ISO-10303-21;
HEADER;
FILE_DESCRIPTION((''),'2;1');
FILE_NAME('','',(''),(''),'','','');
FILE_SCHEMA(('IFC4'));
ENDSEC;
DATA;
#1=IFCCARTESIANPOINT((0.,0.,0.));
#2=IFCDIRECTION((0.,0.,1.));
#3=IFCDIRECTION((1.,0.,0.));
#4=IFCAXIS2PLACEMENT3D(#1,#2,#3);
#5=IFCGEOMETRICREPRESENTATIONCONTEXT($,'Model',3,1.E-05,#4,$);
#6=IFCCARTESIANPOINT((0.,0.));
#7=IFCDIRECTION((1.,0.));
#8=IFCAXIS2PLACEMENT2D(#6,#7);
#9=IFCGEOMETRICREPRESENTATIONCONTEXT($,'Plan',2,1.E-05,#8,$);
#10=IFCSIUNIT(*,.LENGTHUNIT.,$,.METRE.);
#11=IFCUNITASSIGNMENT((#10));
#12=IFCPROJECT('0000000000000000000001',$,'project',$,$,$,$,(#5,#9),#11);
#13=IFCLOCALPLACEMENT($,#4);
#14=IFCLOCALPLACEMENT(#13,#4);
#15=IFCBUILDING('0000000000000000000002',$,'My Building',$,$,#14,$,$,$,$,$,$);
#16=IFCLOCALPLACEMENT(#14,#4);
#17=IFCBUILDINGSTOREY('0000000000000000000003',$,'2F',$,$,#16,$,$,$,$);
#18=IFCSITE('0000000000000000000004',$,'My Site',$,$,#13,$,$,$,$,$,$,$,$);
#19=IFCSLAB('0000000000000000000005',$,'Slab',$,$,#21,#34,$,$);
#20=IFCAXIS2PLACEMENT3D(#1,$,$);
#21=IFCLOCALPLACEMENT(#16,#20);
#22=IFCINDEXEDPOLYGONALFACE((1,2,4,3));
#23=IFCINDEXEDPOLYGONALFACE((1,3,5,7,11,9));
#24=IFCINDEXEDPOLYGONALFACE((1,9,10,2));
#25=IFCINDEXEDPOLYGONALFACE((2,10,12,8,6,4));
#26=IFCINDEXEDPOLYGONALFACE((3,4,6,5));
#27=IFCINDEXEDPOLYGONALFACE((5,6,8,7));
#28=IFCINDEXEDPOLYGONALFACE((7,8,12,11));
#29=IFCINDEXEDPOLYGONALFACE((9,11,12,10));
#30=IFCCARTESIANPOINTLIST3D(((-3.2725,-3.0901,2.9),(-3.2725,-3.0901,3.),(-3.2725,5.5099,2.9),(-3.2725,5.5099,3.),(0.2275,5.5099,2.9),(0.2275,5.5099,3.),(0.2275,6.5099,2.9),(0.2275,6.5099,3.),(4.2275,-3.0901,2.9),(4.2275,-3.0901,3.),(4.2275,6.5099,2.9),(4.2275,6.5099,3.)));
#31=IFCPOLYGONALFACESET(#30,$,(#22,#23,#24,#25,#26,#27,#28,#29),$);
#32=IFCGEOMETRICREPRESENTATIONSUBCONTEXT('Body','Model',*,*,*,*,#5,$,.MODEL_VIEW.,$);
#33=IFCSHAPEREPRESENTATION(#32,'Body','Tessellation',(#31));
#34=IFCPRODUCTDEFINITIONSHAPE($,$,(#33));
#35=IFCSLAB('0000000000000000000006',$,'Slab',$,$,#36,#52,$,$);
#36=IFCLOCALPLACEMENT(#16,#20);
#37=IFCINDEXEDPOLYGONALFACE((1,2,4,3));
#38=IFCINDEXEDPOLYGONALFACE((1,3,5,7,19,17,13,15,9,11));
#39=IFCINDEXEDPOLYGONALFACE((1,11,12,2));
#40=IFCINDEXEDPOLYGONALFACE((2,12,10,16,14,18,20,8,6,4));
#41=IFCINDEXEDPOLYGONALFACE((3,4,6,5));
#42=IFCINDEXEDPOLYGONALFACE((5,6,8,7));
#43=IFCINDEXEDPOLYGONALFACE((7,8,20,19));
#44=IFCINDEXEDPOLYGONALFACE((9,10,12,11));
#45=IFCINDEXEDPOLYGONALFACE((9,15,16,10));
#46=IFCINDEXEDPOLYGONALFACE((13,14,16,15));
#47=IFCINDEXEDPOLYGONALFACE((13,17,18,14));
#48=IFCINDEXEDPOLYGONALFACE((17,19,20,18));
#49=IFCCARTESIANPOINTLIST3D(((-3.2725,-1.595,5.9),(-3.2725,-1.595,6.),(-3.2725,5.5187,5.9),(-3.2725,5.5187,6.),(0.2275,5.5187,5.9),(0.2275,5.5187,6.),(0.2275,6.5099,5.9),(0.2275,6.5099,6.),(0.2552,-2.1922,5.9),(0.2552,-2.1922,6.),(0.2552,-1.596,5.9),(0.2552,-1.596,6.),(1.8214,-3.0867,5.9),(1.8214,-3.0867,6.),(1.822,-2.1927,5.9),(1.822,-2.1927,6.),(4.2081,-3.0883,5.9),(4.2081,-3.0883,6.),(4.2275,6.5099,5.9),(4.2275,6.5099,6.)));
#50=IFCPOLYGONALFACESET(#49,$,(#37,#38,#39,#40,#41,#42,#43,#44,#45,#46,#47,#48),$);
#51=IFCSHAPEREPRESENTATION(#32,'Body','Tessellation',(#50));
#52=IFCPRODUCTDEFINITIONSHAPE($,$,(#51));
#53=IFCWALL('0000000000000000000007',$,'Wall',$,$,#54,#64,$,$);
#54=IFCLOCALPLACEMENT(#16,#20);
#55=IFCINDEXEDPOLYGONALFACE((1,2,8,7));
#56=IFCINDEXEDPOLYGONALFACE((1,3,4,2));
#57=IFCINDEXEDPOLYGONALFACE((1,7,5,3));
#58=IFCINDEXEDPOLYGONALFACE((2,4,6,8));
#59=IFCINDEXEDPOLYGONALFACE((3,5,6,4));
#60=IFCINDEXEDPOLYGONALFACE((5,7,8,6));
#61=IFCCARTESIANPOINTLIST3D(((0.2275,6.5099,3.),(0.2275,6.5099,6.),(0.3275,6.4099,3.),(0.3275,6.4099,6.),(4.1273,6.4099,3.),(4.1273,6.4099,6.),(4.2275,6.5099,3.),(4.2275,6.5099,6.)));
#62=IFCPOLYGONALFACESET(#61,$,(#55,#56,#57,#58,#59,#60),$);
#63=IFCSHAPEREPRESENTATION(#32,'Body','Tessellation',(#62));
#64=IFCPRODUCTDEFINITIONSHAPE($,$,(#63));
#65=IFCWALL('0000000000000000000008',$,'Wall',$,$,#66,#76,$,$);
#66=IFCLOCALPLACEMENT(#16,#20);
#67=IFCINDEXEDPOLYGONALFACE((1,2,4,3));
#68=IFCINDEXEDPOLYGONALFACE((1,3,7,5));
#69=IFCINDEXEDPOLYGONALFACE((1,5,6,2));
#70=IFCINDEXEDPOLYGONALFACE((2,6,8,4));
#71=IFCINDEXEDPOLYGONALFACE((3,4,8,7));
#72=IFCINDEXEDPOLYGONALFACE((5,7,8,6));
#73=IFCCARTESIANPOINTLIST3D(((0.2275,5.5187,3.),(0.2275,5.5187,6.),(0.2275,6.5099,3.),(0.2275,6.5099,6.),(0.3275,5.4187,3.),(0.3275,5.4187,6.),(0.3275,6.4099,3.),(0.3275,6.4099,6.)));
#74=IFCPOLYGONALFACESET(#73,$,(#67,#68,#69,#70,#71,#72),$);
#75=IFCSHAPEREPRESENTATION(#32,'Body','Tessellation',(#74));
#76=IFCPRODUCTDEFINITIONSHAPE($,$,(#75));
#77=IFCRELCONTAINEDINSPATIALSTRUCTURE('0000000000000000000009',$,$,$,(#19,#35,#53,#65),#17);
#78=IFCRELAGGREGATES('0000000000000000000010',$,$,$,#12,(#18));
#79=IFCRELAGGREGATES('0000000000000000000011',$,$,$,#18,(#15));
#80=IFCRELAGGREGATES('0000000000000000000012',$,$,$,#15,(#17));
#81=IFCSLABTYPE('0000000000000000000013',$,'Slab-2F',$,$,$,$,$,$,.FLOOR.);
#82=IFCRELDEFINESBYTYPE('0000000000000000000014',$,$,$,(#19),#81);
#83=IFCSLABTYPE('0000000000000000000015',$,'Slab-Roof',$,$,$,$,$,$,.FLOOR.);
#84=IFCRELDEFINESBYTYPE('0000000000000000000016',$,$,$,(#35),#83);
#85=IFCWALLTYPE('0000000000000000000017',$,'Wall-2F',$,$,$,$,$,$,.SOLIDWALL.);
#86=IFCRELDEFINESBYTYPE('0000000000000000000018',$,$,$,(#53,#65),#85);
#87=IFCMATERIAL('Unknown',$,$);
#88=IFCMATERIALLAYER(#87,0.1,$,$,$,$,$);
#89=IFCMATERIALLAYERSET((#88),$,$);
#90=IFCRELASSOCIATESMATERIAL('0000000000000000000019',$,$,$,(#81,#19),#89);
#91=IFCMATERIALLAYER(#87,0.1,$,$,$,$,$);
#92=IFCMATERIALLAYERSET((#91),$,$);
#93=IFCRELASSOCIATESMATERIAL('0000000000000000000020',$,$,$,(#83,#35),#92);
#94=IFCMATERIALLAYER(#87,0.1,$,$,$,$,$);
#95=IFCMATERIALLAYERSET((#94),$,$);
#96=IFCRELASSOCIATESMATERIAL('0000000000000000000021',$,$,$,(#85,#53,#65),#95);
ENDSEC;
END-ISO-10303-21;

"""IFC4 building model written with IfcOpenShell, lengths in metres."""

from ifc_helpers import new_model, si_unit, frame, origin_with_axes, origin_2d_with_axis, place, context, subcontext, project, spatial, line, indexed_curve, outline, extrude, material, layer, layer_set, layer_usage, type_object, element, save


model = new_model("IFC4")

# Units and contexts
model_context = context("Model", 3, precision=1e-05, world=origin_with_axes())
plan_context = context("Plan", 2, precision=1e-05, world=origin_2d_with_axis())
body_context_1 = subcontext(model_context, "Body", "Model", "MODEL_VIEW")
ifc_project = project(units=[si_unit("LENGTHUNIT", "METRE")], contexts=[model_context, plan_context])

# Site, building, storey
site_placement = place(None, origin_with_axes())
site = spatial("IfcSite", under=ifc_project, at=site_placement, Name="My Site")
building_placement = place(site_placement, origin_with_axes())
building = spatial("IfcBuilding", under=site, at=building_placement, Name="My Building")
storey_placement = place(building_placement, origin_with_axes())
storey = spatial("IfcBuildingStorey", under=building, at=storey_placement, Name="2F")

# Slabs
ifc_material_1 = material(Name="Unknown")
ifc_layer_1 = layer(ifc_material_1, 0.1)
ifc_layer_set_1 = layer_set([ifc_layer_1])
ifc_layer_usage_1 = layer_usage(ifc_layer_set_1, "AXIS3", "POSITIVE", -0.1)
slab_type_1 = type_object("IfcSlabType", Name="Slab-2F", PredefinedType="FLOOR", material=ifc_layer_set_1)
slab_1_placement = place(storey_placement, frame((4.2275, 6.5099, 3.0), z_axis=(0.0, 0.0, 1.0), x_axis=(1.0, 0.0, 0.0)))
element("IfcSlab", 1, at=slab_1_placement, inside=storey, type_object=slab_type_1, material=ifc_layer_usage_1, Name="Slab", context=body_context_1, shape_type="SweptSolid", body=[
    extrude(outline(indexed_curve([(0.0, 0.0), (-4.0, 0.0), (-4.0, -1.0), (-7.5, -1.0), (-7.5, -9.6), (0.0, -9.6), (0.0, 0.0)])), frame((0.0, 0.0, -0.1), z_axis=(0.0, 0.0, 1.0), x_axis=(1.0, 0.0, 0.0)), (0.0, 0.0, 1.0), 0.1),
])
ifc_layer_2 = layer(ifc_material_1, 0.1)
ifc_layer_set_2 = layer_set([ifc_layer_2])
ifc_layer_usage_2 = layer_usage(ifc_layer_set_2, "AXIS3", "POSITIVE", -0.1)
slab_type_2 = type_object("IfcSlabType", Name="Slab-Roof", PredefinedType="FLOOR", material=ifc_layer_set_2)
slab_2_placement = place(storey_placement, frame((4.2275, 6.5099, 6.0), z_axis=(0.0, 0.0, 1.0), x_axis=(1.0, 0.0, 0.0)))
element("IfcSlab", 2, at=slab_2_placement, inside=storey, type_object=slab_type_2, material=ifc_layer_usage_2, Name="Slab", context=body_context_1, shape_type="SweptSolid", body=[
    extrude(outline(indexed_curve([(0.0, 0.0), (-4.0, 0.0), (-4.0, -0.9913), (-7.5, -0.9913), (-7.5, -8.1049), (-3.9723, -8.1059), (-3.9723, -8.7022), (-2.4055, -8.7026), (-2.4061, -9.5967), (-0.0194, -9.5982), (0.0, 0.0)])), frame((0.0, 0.0, -0.1), z_axis=(0.0, 0.0, 1.0), x_axis=(1.0, 0.0, 0.0)), (0.0, 0.0, 1.0), 0.1),
])

# Walls
ifc_layer_3 = layer(ifc_material_1, 0.1)
ifc_layer_set_3 = layer_set([ifc_layer_3])
ifc_layer_usage_3 = layer_usage(ifc_layer_set_3, "AXIS2", "POSITIVE", 0.0)
wall_type = type_object("IfcWallType", Name="Wall-2F", PredefinedType="SOLIDWALL", material=ifc_layer_set_3)
wall_1_placement = place(storey_placement, frame((4.2275, 6.5099, 3.0), z_axis=(0.0, 0.0, 1.0), x_axis=(-1.0, 0.0, 0.0)))
element("IfcWall", 3, at=wall_1_placement, inside=storey, type_object=wall_type, material=ifc_layer_usage_3, Name="Wall", context=body_context_1, shape_type="SweptSolid", body=[
    extrude(outline(indexed_curve([(0.0, 0.0), (0.1002, 0.1), (3.9, 0.1), (4.0, 0.0)], segments=[line(1, 2, 3, 4, 1)])), origin_with_axes(), (0.0, 0.0, 1.0), 3.0),
])
ifc_layer_usage_4 = layer_usage(ifc_layer_set_3, "AXIS2", "POSITIVE", 0.0)
wall_2_placement = place(storey_placement, frame((0.2275, 6.5099, 3.0), z_axis=(0.0, 0.0, 1.0), x_axis=(0.0, -1.0, 0.0)))
element("IfcWall", 4, at=wall_2_placement, inside=storey, type_object=wall_type, material=ifc_layer_usage_4, Name="Wall", context=body_context_1, shape_type="SweptSolid", body=[
    extrude(outline(indexed_curve([(0.0, 0.0), (0.1, 0.1), (1.0913, 0.1), (0.9913, 0.0)], segments=[line(1, 2, 3, 4, 1)])), origin_with_axes(), (0.0, 0.0, 1.0), 3.0),
])

save(model, "model.ifc")
